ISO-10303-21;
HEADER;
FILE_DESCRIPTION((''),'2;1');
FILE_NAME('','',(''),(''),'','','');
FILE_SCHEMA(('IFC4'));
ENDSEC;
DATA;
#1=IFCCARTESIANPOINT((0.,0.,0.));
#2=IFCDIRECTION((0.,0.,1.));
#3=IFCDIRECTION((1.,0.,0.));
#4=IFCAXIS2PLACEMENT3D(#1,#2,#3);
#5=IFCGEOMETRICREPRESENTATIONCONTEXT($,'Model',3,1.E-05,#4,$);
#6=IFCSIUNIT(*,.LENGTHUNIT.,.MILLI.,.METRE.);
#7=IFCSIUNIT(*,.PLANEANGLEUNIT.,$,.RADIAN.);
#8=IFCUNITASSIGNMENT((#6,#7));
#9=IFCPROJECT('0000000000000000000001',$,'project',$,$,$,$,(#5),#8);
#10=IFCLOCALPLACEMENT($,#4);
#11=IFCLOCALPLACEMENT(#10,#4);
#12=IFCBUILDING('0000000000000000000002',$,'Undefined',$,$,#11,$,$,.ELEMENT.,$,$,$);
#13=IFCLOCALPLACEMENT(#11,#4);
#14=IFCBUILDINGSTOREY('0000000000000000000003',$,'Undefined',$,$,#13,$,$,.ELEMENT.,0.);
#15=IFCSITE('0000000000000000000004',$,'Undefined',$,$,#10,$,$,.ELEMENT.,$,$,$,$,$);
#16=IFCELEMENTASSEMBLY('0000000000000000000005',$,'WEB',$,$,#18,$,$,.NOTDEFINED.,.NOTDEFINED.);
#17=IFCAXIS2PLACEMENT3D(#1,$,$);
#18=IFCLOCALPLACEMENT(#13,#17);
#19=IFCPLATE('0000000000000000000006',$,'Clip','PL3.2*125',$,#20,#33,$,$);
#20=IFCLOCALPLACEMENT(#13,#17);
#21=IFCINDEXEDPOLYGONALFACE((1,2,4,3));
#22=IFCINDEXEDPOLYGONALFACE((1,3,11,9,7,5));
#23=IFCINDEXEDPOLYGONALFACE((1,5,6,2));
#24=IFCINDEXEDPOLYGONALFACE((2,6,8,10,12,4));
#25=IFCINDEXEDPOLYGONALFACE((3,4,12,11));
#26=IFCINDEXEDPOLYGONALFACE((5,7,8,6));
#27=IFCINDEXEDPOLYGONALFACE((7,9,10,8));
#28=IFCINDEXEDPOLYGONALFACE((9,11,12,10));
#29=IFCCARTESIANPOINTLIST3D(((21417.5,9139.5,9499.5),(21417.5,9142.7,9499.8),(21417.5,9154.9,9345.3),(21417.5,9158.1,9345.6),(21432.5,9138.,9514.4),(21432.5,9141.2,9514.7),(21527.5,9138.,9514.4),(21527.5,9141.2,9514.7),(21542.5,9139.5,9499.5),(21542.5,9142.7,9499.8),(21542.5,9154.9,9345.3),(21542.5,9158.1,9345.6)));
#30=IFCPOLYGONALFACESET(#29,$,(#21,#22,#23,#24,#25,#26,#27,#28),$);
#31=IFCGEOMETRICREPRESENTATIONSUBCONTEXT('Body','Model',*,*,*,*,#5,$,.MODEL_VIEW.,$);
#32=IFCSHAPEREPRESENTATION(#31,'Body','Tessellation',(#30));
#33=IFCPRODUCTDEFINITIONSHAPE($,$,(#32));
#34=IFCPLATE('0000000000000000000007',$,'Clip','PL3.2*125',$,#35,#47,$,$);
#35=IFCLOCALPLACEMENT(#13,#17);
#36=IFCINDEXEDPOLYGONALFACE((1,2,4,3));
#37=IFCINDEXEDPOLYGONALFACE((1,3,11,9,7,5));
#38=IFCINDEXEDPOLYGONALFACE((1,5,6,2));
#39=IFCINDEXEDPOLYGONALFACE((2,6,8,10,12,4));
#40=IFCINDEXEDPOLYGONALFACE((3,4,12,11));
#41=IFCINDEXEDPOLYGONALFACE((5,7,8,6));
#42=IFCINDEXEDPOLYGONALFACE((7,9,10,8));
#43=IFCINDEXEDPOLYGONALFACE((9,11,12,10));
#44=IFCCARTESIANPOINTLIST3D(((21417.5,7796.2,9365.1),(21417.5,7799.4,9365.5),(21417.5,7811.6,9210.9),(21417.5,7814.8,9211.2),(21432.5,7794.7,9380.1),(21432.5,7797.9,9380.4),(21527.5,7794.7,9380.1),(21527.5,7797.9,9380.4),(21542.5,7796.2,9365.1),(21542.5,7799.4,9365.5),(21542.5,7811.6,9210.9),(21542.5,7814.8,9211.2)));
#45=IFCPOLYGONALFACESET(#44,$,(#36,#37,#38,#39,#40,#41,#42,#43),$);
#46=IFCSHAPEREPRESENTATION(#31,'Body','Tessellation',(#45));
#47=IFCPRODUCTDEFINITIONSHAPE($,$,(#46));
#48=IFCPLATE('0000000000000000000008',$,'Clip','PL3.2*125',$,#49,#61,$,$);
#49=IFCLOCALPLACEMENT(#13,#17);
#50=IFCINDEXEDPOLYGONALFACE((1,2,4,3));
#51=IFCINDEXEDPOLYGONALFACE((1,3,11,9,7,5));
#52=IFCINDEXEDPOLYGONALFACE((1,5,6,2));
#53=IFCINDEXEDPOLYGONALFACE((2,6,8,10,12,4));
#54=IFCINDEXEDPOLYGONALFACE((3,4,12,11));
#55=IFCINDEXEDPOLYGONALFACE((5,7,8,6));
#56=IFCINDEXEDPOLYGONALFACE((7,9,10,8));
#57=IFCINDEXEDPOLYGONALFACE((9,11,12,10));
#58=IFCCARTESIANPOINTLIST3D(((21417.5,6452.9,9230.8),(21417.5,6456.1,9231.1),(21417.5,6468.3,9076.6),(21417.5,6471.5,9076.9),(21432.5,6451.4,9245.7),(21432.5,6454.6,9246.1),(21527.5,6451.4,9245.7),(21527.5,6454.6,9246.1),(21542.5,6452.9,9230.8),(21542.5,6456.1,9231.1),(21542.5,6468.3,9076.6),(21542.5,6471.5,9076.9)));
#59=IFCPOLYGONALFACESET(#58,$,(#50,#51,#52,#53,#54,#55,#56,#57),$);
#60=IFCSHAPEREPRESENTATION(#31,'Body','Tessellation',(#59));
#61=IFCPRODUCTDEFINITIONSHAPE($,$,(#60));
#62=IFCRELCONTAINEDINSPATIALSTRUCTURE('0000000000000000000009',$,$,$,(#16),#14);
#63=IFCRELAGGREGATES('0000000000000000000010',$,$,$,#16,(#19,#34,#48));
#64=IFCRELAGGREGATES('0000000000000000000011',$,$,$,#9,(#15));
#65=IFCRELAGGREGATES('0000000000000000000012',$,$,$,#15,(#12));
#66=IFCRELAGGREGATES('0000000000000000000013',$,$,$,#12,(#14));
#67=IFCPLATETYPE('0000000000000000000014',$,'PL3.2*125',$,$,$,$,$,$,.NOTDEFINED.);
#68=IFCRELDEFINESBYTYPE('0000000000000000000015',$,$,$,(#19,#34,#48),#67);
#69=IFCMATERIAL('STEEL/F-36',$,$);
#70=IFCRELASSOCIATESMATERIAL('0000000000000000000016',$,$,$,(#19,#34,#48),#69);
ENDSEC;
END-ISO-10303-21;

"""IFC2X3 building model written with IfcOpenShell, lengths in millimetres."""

from ifc_helpers import new_model, si_unit, frame, origin_with_axes, place, context, subcontext, project, spatial, polyline, outline, extrude, material, type_object, element, aggregate, save


model = new_model("IFC2X3")

# Units and contexts
model_context = context("Model", 3, precision=1e-05, world=origin_with_axes())
body_context = subcontext(model_context, "Body", "Model", "MODEL_VIEW")
ifc_project = project(units=[si_unit("LENGTHUNIT", "METRE", prefix="MILLI"), si_unit("PLANEANGLEUNIT", "RADIAN")], contexts=[model_context])

# Site, building, storey
site_placement = place(None, origin_with_axes())
site = spatial("IfcSite", under=ifc_project, at=site_placement, Name="Undefined", CompositionType="ELEMENT")
building_placement = place(site_placement, origin_with_axes())
building = spatial("IfcBuilding", under=site, at=building_placement, Name="Undefined", CompositionType="ELEMENT")
storey_placement = place(building_placement, origin_with_axes())
storey = spatial("IfcBuildingStorey", under=building, at=storey_placement, Name="Undefined", CompositionType="ELEMENT", Elevation=0.0)

# Element assembly, plates
assembly_1_placement = place(storey_placement, origin_with_axes())
assembly_1 = element("IfcElementAssembly", 1, at=assembly_1_placement, inside=storey, Name="WEB", AssemblyPlace="NOTDEFINED", PredefinedType="NOTDEFINED")
ifc_material_1 = material(Name="STEEL/F-36")
plate_type = type_object("IfcPlateType", Name="PL3.2*125", PredefinedType="NOTDEFINED")
plate_1_placement = place(assembly_1_placement, frame((21542.5, 9156.5, 9345.4), z_axis=(0.0, 0.995037, 0.099504), x_axis=(-1.0, 0.0, 0.0)))
plate_1 = element("IfcPlate", 2, at=plate_1_placement, type_object=plate_type, material=ifc_material_1, Name="Clip", Description="PL3.2*125", context=body_context, shape_type="SweptSolid", body=[
    extrude(outline(polyline([(0.0, 0.0), (125.0, 0.0), (125.0, 155.0), (110.0, 170.0), (15.0, 170.0), (0.0, 155.0), (0.0, 0.0)])), frame((0.0, 0.0, -1.6), z_axis=(0.0, 0.0, 1.0), x_axis=(1.0, 0.0, 0.0)), (0.0, 0.0, 1.0), 3.2),
])
plate_2_placement = place(assembly_1_placement, frame((21542.5, 7813.2, 9211.1), z_axis=(0.0, 0.995037, 0.099504), x_axis=(-1.0, 0.0, 0.0)))
plate_2 = element("IfcPlate", 3, at=plate_2_placement, type_object=plate_type, material=ifc_material_1, Name="Clip", Description="PL3.2*125", context=body_context, shape_type="SweptSolid", body=[
    extrude(outline(polyline([(0.0, 0.0), (125.0, 0.0), (125.0, 155.0), (110.0, 170.0), (15.0, 170.0), (0.0, 155.0), (0.0, 0.0)])), frame((0.0, 0.0, -1.6), z_axis=(0.0, 0.0, 1.0), x_axis=(1.0, 0.0, 0.0)), (0.0, 0.0, 1.0), 3.2),
])
plate_3_placement = place(assembly_1_placement, frame((21542.5, 6469.9, 9076.8), z_axis=(0.0, 0.995037, 0.099504), x_axis=(-1.0, 0.0, 0.0)))
plate_3 = element("IfcPlate", 4, at=plate_3_placement, type_object=plate_type, material=ifc_material_1, Name="Clip", Description="PL3.2*125", context=body_context, shape_type="SweptSolid", body=[
    extrude(outline(polyline([(0.0, 0.0), (125.0, 0.0), (125.0, 155.0), (110.0, 170.0), (15.0, 170.0), (0.0, 155.0), (0.0, 0.0)])), frame((0.0, 0.0, -1.6), z_axis=(0.0, 0.0, 1.0), x_axis=(1.0, 0.0, 0.0)), (0.0, 0.0, 1.0), 3.2),
])
aggregate(assembly_1, [plate_1, plate_2, plate_3])

save(model, "model.ifc")
